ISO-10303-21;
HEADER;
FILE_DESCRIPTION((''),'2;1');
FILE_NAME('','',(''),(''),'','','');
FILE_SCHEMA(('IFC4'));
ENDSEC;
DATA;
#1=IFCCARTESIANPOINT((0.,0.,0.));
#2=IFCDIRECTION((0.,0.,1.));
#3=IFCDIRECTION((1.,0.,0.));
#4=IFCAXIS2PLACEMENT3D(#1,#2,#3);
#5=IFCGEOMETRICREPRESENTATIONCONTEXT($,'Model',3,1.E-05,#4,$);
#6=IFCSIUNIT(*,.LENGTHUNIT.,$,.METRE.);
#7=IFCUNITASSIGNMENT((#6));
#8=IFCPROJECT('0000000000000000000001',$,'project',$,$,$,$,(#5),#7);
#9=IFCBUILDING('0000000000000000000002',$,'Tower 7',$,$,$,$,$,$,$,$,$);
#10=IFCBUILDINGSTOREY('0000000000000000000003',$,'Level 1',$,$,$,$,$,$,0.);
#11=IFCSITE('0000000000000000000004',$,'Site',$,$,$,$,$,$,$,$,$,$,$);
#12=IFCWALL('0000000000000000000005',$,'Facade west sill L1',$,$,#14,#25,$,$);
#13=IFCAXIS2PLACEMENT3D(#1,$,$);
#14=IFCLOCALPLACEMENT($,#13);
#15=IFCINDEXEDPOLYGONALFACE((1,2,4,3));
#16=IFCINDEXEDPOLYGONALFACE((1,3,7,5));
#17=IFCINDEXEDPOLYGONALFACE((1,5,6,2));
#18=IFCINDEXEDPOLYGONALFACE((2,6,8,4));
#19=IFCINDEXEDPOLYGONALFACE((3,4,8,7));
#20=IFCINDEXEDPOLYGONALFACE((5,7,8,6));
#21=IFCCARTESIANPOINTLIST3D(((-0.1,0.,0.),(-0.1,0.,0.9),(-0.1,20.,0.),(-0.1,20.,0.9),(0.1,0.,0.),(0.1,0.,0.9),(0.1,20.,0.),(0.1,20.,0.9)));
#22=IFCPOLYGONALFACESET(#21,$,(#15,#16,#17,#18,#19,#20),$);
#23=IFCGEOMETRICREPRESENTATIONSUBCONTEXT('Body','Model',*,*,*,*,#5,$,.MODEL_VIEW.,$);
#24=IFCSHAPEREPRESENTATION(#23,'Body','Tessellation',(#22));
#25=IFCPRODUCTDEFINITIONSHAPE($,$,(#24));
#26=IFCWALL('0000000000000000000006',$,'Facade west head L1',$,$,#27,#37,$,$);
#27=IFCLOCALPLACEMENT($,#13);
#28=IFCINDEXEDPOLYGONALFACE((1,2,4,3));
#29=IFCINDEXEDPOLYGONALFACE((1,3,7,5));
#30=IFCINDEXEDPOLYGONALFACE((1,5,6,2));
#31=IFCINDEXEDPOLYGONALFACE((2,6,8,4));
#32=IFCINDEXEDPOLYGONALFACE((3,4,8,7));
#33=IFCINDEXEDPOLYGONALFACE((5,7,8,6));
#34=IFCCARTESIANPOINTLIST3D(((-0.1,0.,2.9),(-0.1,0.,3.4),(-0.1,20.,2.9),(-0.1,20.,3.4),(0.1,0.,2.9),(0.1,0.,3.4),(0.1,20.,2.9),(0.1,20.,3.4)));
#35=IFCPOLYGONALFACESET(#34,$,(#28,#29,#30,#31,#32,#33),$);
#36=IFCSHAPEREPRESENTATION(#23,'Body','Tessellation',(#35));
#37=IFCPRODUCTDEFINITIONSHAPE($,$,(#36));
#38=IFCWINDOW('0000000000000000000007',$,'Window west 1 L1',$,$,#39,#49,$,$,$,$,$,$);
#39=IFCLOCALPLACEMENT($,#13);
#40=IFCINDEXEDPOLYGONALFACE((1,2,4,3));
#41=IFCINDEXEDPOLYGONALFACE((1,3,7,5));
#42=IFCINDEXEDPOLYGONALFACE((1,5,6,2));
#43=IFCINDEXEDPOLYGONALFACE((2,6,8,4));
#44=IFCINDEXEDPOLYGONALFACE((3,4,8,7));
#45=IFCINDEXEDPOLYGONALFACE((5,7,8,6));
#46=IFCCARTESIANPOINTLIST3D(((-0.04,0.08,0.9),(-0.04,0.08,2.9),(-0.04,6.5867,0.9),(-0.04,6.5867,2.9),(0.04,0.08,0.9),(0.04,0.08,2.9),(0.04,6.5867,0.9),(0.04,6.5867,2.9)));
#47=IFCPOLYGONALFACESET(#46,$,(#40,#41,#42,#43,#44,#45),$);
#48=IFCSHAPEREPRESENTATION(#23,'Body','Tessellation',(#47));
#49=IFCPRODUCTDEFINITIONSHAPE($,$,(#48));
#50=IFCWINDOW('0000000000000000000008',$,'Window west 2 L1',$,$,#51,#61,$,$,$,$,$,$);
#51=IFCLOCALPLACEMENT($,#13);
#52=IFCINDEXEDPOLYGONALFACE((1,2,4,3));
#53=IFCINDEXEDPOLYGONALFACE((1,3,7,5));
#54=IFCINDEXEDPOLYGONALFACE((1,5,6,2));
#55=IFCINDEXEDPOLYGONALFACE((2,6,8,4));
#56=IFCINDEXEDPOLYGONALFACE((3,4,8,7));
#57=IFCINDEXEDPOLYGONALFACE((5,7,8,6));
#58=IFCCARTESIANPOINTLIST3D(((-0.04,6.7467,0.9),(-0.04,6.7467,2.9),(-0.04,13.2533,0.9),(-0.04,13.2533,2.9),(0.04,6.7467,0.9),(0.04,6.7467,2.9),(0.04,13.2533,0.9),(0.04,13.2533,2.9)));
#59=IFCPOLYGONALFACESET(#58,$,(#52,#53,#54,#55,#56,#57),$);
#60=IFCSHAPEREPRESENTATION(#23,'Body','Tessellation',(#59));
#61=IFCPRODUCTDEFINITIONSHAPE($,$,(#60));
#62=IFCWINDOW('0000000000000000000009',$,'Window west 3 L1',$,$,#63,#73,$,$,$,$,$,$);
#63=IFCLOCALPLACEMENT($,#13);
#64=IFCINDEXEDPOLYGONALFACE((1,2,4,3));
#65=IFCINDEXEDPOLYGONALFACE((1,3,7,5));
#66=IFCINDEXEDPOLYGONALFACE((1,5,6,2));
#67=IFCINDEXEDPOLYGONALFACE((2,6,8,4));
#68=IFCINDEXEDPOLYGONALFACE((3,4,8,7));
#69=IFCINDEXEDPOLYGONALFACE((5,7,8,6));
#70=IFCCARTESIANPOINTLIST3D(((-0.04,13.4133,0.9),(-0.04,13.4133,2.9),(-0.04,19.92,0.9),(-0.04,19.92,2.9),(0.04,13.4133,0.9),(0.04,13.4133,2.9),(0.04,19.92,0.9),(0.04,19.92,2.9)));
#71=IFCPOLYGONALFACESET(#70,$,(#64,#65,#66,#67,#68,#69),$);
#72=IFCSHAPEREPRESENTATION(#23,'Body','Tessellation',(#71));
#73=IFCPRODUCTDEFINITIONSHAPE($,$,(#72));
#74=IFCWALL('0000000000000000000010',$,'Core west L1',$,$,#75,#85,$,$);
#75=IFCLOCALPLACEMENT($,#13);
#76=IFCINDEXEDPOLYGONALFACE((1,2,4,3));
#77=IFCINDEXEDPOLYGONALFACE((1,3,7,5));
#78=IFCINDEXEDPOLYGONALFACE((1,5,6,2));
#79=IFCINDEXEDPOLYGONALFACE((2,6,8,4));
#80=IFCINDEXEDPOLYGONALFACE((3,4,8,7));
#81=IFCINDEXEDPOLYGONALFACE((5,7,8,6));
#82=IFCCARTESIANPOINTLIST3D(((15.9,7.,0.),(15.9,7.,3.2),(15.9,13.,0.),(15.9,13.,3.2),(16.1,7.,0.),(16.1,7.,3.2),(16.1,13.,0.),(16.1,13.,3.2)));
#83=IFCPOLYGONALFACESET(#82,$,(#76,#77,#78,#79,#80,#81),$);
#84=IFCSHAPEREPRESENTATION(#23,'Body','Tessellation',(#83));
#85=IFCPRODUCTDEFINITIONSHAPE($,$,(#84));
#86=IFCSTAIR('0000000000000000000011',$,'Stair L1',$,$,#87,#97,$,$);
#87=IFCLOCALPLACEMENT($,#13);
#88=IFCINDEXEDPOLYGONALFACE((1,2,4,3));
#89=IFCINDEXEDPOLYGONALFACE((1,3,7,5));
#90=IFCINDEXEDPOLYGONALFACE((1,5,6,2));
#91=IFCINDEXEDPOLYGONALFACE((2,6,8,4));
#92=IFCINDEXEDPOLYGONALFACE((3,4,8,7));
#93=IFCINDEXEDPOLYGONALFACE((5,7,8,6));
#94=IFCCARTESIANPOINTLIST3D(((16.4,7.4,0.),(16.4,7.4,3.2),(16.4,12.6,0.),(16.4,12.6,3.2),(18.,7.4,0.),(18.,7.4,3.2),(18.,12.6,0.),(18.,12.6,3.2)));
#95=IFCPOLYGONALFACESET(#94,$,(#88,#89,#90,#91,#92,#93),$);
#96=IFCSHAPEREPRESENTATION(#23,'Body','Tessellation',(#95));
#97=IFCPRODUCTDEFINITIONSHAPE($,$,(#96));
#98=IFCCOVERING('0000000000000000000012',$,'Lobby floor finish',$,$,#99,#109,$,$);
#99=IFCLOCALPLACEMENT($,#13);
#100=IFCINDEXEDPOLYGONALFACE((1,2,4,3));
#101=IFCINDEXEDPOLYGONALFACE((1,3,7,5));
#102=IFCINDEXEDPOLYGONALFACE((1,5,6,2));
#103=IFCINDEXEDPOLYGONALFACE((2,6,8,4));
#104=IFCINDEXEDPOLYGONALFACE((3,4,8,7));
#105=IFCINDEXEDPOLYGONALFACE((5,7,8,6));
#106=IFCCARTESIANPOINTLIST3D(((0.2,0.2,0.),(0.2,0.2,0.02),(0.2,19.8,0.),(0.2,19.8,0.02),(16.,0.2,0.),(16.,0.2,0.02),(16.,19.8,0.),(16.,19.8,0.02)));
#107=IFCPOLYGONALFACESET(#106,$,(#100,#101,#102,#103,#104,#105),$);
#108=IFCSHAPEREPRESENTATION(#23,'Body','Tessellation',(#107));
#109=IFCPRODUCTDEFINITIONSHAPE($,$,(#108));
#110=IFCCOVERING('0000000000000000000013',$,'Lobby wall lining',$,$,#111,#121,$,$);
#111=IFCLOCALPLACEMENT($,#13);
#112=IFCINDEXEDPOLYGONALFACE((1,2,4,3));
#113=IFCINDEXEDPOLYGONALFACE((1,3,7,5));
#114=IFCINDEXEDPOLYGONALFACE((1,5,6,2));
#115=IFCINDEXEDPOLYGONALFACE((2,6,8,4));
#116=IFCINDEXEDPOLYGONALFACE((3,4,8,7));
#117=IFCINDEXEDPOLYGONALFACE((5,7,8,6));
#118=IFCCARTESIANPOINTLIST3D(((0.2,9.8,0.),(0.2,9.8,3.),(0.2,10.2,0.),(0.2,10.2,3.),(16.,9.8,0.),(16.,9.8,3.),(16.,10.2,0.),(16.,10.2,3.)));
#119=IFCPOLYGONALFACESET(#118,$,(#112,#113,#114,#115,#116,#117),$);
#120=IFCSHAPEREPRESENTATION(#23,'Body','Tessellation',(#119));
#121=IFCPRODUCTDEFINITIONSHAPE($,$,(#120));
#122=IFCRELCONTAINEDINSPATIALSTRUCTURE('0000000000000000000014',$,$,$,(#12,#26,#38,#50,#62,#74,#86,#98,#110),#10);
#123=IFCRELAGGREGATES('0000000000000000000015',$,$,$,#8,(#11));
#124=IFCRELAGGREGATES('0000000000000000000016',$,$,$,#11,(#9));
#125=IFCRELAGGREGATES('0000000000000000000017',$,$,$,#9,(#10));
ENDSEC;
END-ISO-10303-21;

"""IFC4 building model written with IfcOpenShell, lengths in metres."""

from ifc_helpers import new_model, si_unit, frame, origin, origin_with_axes, origin_2d, place, context, subcontext, project, spatial, rectangle, extrude, element, save


model = new_model("IFC4")

# Units and contexts
model_context = context("Model", 3, precision=1e-05, world=origin_with_axes())
body_context = subcontext(model_context, "Body", "Model", "MODEL_VIEW")
ifc_project = project(units=[si_unit("LENGTHUNIT", "METRE")], contexts=[model_context])

# Site, building, storey
site = spatial("IfcSite", under=ifc_project, Name="Site")
building = spatial("IfcBuilding", under=site, Name="Tower 7")
storey = spatial("IfcBuildingStorey", under=building, Name="Level 1", Elevation=0.0)

# Walls
wall_1_placement = place(None, frame((0.0, 10.0, 0.0), z_axis=(0.0, 0.0, 1.0), x_axis=(1.0, 0.0, 0.0)))
element("IfcWall", 1, at=wall_1_placement, inside=storey, Name="Facade west sill L1", context=body_context, shape_type="SweptSolid", body=[
    extrude(rectangle(XDim=0.2, YDim=20.0, at=origin_2d()), origin(), (0.0, 0.0, 1.0), 0.9),
])
wall_2_placement = place(None, frame((0.0, 10.0, 2.9), z_axis=(0.0, 0.0, 1.0), x_axis=(1.0, 0.0, 0.0)))
element("IfcWall", 2, at=wall_2_placement, inside=storey, Name="Facade west head L1", context=body_context, shape_type="SweptSolid", body=[
    extrude(rectangle(XDim=0.2, YDim=20.0, at=origin_2d()), origin(), (0.0, 0.0, 1.0), 0.5),
])

# Windows
for number, where, z_axis, x_axis, name in (
    (3, (0.0, 3.3333, 0.9), (0.0, 0.0, 1.0), (1.0, 0.0, 0.0), "Window west 1 L1"),
    (4, (0.0, 10.0, 0.9), (0.0, 0.0, 1.0), (1.0, 0.0, 0.0), "Window west 2 L1"),
):
    element("IfcWindow", number, at=place(None, frame(where, z_axis=z_axis, x_axis=x_axis)), inside=storey, Name=name, context=body_context, shape_type="SweptSolid", body=[
        extrude(rectangle(XDim=0.08, YDim=6.5067, at=origin_2d()), origin(), (0.0, 0.0, 1.0), 2.0),
    ])
window_1_placement = place(None, frame((0.0, 16.6667, 0.9), z_axis=(0.0, 0.0, 1.0), x_axis=(1.0, 0.0, 0.0)))
element("IfcWindow", 5, at=window_1_placement, inside=storey, Name="Window west 3 L1", context=body_context, shape_type="SweptSolid", body=[
    extrude(rectangle(XDim=0.08, YDim=6.5067, at=origin_2d()), origin(), (0.0, 0.0, 1.0), 2.0),
])

# Wall
wall_3_placement = place(None, frame((16.0, 10.0, 0.0), z_axis=(0.0, 0.0, 1.0), x_axis=(1.0, 0.0, 0.0)))
element("IfcWall", 6, at=wall_3_placement, inside=storey, Name="Core west L1", context=body_context, shape_type="SweptSolid", body=[
    extrude(rectangle(XDim=0.2, YDim=6.0, at=origin_2d()), origin(), (0.0, 0.0, 1.0), 3.2),
])

# Stair
stair_placement = place(None, frame((17.2, 10.0, 0.0), z_axis=(0.0, 0.0, 1.0), x_axis=(1.0, 0.0, 0.0)))
element("IfcStair", 7, at=stair_placement, inside=storey, Name="Stair L1", context=body_context, shape_type="SweptSolid", body=[
    extrude(rectangle(XDim=1.6, YDim=5.2, at=origin_2d()), origin(), (0.0, 0.0, 1.0), 3.2),
])

# Coverings
covering_1_placement = place(None, frame((8.1, 10.0, 0.0), z_axis=(0.0, 0.0, 1.0), x_axis=(1.0, 0.0, 0.0)))
element("IfcCovering", 8, at=covering_1_placement, inside=storey, Name="Lobby floor finish", context=body_context, shape_type="SweptSolid", body=[
    extrude(rectangle(XDim=15.8, YDim=19.6, at=origin_2d()), origin(), (0.0, 0.0, 1.0), 0.02),
])
covering_2_placement = place(None, frame((8.1, 10.0, 0.0), z_axis=(0.0, 0.0, 1.0), x_axis=(1.0, 0.0, 0.0)))
element("IfcCovering", 9, at=covering_2_placement, inside=storey, Name="Lobby wall lining", context=body_context, shape_type="SweptSolid", body=[
    extrude(rectangle(XDim=15.8, YDim=0.4, at=origin_2d()), origin(), (0.0, 0.0, 1.0), 3.0),
])

save(model, "model.ifc")
